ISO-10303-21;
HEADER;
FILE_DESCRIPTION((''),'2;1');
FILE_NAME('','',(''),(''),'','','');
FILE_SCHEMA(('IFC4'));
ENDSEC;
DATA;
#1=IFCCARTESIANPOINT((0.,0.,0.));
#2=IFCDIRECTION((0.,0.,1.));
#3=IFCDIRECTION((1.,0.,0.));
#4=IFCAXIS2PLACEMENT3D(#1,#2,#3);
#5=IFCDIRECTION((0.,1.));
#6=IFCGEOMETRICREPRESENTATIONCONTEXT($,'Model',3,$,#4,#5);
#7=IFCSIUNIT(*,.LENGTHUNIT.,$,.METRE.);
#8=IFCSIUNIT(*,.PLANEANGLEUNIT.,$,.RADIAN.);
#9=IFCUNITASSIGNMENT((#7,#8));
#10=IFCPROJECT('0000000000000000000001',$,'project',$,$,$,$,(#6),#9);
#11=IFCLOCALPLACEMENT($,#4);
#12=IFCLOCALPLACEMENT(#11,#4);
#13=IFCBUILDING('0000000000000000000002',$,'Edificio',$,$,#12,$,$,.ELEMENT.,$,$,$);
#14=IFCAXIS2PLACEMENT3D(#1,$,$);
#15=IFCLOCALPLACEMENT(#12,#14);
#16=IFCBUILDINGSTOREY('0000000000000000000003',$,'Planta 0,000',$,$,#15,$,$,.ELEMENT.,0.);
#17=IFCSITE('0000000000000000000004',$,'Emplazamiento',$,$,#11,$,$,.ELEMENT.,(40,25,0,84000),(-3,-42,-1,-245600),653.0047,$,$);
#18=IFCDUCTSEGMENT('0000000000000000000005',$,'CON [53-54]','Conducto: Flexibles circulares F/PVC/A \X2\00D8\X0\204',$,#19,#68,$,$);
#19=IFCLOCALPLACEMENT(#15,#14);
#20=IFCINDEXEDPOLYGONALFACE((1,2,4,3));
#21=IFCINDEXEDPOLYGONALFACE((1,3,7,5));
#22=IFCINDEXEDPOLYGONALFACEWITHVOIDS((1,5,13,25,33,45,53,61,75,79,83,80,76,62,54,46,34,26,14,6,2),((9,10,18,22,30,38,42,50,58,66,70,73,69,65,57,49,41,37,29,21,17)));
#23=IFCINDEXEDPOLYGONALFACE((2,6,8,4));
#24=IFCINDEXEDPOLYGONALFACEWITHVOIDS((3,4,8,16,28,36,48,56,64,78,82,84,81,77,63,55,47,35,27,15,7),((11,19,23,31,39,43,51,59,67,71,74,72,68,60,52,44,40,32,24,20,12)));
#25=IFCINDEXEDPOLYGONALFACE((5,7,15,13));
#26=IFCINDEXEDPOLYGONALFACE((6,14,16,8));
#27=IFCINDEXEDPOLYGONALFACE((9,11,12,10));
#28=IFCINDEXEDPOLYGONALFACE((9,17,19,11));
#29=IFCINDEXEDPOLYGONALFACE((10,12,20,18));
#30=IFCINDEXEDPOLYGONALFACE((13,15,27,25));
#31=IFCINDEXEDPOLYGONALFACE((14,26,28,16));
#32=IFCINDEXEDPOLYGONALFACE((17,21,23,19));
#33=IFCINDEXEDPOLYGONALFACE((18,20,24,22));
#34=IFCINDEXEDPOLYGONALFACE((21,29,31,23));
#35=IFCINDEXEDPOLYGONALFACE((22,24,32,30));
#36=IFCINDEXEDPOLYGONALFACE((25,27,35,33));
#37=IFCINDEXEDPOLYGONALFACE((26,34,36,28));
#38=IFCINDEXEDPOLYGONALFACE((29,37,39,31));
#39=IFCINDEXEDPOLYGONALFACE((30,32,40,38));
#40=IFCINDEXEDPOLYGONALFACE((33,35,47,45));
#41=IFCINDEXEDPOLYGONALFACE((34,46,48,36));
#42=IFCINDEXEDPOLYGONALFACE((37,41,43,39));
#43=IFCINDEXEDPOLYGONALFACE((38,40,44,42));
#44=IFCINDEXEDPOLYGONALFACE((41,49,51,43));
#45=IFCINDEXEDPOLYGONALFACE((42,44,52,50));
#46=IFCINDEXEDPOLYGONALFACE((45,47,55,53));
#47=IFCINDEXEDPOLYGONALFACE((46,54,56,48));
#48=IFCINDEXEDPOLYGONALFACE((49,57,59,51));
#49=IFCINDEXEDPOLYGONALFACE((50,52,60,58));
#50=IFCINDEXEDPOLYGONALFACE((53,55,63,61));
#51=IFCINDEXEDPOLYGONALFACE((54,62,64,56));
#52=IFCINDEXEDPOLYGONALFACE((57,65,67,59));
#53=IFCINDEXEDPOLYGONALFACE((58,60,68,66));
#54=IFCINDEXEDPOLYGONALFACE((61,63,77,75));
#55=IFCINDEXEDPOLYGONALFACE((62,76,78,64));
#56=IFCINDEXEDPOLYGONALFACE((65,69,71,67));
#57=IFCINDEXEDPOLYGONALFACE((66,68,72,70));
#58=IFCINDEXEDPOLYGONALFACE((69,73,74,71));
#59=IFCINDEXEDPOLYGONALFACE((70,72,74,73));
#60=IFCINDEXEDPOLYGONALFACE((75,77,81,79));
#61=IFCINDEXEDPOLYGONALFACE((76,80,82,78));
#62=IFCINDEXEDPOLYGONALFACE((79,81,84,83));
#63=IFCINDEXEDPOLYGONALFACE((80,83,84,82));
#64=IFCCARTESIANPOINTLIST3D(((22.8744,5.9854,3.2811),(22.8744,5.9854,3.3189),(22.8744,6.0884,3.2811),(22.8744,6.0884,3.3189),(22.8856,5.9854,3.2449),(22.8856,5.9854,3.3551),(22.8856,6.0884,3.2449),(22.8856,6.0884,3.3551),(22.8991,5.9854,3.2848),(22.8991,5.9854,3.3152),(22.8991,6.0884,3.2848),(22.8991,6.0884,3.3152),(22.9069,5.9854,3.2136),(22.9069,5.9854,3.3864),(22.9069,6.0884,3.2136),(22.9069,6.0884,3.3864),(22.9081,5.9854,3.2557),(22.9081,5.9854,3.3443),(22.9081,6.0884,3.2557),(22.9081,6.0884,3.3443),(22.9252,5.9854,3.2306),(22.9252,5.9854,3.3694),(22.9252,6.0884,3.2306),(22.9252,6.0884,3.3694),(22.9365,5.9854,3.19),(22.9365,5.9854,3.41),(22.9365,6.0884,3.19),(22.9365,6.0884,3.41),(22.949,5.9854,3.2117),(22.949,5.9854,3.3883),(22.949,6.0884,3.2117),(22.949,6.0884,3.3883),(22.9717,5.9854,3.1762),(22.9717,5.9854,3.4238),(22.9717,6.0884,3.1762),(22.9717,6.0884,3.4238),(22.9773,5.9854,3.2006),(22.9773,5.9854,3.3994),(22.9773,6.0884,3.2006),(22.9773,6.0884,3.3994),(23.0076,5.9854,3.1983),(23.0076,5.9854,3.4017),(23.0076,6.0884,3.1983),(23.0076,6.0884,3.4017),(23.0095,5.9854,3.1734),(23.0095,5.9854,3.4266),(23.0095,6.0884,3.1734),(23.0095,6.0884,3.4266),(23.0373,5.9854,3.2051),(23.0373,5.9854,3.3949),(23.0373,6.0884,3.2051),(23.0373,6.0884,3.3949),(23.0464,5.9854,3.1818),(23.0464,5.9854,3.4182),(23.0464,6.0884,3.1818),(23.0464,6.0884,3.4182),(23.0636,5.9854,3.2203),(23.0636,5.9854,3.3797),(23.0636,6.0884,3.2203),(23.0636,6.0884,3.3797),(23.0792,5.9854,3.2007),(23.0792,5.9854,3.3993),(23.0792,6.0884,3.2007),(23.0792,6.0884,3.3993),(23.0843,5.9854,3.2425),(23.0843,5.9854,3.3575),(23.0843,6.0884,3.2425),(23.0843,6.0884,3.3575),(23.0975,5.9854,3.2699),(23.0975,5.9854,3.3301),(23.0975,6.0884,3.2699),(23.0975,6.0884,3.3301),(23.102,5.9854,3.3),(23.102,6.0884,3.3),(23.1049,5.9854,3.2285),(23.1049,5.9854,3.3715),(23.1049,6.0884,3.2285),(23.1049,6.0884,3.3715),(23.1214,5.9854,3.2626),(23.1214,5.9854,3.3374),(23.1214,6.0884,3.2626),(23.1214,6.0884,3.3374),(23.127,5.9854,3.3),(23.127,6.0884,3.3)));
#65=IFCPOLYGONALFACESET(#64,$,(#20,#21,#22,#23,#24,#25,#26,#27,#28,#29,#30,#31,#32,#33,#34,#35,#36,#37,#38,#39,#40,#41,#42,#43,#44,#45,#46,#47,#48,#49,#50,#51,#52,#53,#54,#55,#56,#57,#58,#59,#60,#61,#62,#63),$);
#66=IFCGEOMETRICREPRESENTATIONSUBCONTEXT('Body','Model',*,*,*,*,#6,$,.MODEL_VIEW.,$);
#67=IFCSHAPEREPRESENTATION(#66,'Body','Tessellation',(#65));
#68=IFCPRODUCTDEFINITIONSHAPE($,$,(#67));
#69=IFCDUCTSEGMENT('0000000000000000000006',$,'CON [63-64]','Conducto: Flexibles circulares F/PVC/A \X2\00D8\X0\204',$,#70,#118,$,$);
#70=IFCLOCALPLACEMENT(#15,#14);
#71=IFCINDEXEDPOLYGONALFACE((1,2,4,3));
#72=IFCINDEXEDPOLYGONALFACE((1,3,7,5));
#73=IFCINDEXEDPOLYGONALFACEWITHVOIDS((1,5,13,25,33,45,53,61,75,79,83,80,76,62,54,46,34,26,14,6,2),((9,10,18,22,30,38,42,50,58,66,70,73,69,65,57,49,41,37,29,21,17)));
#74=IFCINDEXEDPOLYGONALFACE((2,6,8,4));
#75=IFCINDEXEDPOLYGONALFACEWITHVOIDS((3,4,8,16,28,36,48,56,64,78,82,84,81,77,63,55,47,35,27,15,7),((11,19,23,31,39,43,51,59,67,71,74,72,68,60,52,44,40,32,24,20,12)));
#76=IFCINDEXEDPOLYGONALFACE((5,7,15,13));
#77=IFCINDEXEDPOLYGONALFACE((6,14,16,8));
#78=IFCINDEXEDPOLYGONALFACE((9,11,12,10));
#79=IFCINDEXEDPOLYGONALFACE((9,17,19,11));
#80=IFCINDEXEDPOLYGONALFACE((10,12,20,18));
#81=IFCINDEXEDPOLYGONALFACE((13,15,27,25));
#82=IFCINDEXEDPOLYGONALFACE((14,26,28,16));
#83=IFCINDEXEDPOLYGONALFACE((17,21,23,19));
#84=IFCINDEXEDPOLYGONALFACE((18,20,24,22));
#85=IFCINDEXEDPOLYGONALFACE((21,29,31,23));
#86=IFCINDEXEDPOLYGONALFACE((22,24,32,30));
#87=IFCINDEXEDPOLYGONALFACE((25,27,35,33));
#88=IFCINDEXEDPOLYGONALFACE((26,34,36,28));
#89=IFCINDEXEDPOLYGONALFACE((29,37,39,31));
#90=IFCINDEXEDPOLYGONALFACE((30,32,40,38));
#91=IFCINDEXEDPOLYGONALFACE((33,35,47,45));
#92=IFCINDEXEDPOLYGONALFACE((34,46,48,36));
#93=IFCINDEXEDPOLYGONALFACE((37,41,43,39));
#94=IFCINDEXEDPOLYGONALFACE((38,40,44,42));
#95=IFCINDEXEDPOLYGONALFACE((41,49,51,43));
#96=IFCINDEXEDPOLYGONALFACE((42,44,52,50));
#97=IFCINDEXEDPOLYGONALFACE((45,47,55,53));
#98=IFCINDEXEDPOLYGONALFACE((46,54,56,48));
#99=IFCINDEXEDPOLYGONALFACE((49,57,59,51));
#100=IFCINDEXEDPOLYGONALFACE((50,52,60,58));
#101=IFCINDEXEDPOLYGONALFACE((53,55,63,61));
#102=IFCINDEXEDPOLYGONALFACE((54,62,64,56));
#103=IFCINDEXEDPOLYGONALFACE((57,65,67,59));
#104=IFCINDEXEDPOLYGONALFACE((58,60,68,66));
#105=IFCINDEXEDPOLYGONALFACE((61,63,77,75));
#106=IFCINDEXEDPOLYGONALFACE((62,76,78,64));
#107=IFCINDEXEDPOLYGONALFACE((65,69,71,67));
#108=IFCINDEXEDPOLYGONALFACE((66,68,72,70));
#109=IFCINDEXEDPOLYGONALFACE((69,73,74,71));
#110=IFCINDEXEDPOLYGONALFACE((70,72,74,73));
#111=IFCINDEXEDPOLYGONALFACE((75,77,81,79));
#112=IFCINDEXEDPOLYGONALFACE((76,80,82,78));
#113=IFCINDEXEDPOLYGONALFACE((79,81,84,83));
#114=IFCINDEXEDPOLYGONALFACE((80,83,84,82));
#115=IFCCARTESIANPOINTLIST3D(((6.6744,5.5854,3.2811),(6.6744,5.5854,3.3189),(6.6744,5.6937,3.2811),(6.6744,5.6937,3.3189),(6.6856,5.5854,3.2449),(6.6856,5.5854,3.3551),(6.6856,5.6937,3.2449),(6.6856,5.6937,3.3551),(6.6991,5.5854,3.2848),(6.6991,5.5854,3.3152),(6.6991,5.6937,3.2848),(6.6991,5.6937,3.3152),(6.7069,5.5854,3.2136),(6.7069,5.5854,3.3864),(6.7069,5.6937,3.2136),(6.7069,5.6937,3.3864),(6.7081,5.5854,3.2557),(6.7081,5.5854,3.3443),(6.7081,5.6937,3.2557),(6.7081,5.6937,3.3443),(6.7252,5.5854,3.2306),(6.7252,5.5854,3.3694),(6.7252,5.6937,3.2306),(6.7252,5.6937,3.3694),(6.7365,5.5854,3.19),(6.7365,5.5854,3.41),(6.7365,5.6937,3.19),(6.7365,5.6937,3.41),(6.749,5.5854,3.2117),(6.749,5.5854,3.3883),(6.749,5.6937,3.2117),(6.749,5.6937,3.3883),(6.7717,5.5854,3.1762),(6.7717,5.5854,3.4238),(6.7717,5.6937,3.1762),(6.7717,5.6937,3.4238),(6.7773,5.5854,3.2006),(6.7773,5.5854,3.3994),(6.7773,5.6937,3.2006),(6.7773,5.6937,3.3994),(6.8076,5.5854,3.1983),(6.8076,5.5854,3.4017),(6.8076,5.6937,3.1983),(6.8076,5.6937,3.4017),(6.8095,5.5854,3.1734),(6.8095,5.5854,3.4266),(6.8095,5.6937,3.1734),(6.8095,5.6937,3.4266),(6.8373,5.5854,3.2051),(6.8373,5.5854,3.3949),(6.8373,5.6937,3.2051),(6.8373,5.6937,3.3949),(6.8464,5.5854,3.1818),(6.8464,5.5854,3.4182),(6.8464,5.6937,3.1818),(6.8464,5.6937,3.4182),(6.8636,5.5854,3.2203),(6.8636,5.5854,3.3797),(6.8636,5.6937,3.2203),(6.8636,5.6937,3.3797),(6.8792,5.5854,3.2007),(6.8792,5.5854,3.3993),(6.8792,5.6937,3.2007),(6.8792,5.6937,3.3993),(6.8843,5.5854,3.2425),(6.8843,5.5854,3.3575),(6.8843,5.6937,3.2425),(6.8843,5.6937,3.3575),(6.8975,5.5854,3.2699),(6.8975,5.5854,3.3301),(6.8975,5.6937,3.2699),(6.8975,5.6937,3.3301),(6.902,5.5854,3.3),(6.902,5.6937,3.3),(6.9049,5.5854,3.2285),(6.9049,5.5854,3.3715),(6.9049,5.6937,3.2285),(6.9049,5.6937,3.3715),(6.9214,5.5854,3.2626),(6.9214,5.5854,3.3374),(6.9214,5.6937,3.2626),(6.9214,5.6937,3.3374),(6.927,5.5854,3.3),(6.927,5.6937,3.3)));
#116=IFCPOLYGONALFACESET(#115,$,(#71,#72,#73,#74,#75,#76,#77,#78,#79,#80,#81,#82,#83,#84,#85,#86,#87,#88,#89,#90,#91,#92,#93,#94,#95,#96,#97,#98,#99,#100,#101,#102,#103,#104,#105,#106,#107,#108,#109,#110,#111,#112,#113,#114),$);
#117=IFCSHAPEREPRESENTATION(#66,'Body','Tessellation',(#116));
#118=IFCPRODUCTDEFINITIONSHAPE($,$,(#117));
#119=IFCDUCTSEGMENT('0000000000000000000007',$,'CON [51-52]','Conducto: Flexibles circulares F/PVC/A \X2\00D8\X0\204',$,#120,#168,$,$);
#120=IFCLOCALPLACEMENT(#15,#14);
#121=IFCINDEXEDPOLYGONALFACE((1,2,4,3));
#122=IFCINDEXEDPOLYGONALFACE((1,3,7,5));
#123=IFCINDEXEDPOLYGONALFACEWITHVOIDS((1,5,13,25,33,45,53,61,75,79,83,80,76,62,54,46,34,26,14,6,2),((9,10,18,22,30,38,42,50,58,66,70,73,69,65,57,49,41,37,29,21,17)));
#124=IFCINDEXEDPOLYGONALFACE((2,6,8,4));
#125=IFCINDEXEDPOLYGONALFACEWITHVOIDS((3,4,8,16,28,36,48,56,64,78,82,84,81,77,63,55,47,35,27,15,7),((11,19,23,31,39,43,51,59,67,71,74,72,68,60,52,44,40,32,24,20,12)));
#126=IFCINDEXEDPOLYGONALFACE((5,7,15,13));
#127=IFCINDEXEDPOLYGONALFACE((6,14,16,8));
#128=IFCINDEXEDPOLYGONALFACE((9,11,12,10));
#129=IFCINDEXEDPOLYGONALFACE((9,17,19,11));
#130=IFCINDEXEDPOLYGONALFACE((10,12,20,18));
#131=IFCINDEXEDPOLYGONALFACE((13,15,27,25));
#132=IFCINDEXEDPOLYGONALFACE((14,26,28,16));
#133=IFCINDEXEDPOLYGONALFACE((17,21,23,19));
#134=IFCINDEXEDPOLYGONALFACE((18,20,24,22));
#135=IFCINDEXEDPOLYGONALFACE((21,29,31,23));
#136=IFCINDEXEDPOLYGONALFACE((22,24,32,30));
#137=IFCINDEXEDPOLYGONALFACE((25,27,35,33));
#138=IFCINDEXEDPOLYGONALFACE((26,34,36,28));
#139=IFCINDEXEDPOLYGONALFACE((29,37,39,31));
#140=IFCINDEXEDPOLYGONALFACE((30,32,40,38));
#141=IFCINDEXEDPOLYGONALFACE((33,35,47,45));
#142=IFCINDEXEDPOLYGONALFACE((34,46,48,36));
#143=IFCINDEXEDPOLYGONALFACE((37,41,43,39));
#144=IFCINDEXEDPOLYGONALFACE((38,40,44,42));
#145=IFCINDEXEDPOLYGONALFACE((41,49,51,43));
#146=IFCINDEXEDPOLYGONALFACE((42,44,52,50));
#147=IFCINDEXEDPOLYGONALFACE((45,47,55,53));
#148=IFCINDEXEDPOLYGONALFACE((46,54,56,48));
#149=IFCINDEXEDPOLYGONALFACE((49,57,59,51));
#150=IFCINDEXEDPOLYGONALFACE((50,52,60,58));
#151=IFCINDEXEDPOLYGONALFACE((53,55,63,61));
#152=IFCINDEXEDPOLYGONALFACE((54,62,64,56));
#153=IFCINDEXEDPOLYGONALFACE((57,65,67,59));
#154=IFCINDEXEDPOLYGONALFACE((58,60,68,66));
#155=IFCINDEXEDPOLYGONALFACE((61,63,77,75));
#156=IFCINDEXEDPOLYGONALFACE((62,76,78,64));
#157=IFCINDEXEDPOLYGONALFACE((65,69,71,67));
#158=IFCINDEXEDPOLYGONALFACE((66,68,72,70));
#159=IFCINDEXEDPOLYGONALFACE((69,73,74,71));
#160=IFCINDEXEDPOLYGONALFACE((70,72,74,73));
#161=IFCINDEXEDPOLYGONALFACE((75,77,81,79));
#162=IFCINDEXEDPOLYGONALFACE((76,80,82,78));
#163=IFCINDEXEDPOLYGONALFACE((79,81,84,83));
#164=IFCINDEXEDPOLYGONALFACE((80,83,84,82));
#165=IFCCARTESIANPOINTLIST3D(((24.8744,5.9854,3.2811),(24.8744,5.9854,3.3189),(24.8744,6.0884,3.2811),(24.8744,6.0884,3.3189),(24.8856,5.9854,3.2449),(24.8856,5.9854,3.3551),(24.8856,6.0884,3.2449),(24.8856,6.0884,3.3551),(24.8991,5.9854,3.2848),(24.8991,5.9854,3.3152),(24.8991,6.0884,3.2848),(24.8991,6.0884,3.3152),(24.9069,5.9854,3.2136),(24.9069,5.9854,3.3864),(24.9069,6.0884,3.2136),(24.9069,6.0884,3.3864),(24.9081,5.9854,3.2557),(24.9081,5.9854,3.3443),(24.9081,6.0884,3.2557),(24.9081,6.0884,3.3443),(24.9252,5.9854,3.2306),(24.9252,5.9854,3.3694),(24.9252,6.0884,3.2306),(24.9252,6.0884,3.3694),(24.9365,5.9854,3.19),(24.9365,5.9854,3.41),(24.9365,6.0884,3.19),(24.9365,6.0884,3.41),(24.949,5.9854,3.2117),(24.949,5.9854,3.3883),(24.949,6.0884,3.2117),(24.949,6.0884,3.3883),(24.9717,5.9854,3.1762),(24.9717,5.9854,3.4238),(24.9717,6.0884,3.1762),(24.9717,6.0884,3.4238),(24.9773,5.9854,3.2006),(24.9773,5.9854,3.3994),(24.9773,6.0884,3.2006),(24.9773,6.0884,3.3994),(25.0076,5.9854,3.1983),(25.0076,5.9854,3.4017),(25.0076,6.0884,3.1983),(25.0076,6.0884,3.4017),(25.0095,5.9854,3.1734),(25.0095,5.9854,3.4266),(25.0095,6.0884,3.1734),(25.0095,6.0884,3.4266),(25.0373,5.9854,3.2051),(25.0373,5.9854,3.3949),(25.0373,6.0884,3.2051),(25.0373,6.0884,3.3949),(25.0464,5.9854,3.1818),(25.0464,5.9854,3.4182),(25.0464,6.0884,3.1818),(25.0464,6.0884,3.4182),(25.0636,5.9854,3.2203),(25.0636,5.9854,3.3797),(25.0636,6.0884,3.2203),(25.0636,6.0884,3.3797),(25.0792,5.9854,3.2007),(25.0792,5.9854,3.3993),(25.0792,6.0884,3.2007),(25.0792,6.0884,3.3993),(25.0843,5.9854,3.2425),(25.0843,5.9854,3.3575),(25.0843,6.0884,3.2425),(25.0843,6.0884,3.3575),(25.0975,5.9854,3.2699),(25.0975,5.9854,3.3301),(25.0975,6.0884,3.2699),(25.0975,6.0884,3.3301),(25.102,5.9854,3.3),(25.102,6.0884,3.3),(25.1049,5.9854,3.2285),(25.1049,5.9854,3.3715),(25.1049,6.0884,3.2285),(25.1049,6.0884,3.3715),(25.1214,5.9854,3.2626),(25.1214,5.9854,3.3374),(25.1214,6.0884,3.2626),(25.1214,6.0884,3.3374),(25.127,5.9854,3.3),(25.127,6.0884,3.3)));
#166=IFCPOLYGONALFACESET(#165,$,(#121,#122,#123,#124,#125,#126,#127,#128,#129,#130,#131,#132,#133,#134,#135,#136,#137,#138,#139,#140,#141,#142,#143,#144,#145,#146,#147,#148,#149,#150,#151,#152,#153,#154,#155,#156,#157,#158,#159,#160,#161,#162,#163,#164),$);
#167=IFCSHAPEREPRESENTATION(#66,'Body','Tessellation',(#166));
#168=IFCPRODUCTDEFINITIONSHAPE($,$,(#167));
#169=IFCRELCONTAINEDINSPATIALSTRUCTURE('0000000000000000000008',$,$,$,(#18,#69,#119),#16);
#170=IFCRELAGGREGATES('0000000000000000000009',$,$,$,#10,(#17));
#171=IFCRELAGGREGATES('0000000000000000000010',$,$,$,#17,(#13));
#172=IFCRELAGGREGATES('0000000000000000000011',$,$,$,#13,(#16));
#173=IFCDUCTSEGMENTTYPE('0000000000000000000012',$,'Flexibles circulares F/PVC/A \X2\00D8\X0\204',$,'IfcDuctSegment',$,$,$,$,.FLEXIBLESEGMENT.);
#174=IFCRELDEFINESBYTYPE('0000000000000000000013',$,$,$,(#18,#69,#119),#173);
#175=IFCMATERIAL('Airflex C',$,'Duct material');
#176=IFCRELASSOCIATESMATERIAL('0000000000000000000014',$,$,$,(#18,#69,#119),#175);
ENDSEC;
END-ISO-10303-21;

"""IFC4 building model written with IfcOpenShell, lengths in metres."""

from ifc_helpers import new_model, si_unit, direction, frame, origin, origin_with_axes, origin_2d_with_axis, place, context, subcontext, project, spatial, hollow_circle, extrude, material, type_object, element, save


model = new_model("IFC4")

# Units and contexts
model_context = context("Model", 3, world=origin_with_axes(), true_north=direction((0.0, 1.0)))
body_context = subcontext(model_context, "Body", "Model", "MODEL_VIEW")
ifc_project = project(units=[si_unit("LENGTHUNIT", "METRE"), si_unit("PLANEANGLEUNIT", "RADIAN")], contexts=[model_context])

# Site, building, storey
site_placement = place(None, origin_with_axes())
site = spatial("IfcSite", under=ifc_project, at=site_placement, Name="Emplazamiento", CompositionType="ELEMENT", RefLatitude=(40, 25, 0, 84000), RefLongitude=(-3, -42, -1, -245600), RefElevation=653.0047)
building_placement = place(site_placement, origin_with_axes())
building = spatial("IfcBuilding", under=site, at=building_placement, Name="Edificio", CompositionType="ELEMENT")
storey_placement = place(building_placement, origin())
storey = spatial("IfcBuildingStorey", under=building, at=storey_placement, Name="Planta 0,000", CompositionType="ELEMENT", Elevation=0.0)

# Shared definitions
ifc_material_1 = material(Name="Airflex C", Category="Duct material")

# Duct segments
duct_segment_type_1 = type_object("IfcDuctSegmentType", Name="Flexibles circulares F/PVC/A Ø204", ApplicableOccurrence="IfcDuctSegment", PredefinedType="FLEXIBLESEGMENT")
duct_segment_1_placement = place(storey_placement, origin_with_axes())
element("IfcDuctSegment", 1, at=duct_segment_1_placement, inside=storey, type_object=duct_segment_type_1, material=ifc_material_1, Name="CON [53-54]", Description="Conducto: Flexibles circulares F/PVC/A Ø204", context=body_context, shape_type="SweptSolid", body=[
    extrude(hollow_circle(Radius=0.127, WallThickness=0.025, at=origin_2d_with_axis()), frame((23.0, 6.0884, 3.3), z_axis=(0.0, -1.0, 0.0), x_axis=(1.0, 0.0, 0.0)), (0.0, 0.0, 1.0), 0.103),
])
duct_segment_2_placement = place(storey_placement, origin_with_axes())
element("IfcDuctSegment", 2, at=duct_segment_2_placement, inside=storey, type_object=duct_segment_type_1, material=ifc_material_1, Name="CON [63-64]", Description="Conducto: Flexibles circulares F/PVC/A Ø204", context=body_context, shape_type="SweptSolid", body=[
    extrude(hollow_circle(Radius=0.127, WallThickness=0.025, at=origin_2d_with_axis()), frame((6.8, 5.6937, 3.3), z_axis=(0.0, -1.0, 0.0), x_axis=(1.0, 0.0, 0.0)), (0.0, 0.0, 1.0), 0.1082),
])
duct_segment_3_placement = place(storey_placement, origin_with_axes())
element("IfcDuctSegment", 3, at=duct_segment_3_placement, inside=storey, type_object=duct_segment_type_1, material=ifc_material_1, Name="CON [51-52]", Description="Conducto: Flexibles circulares F/PVC/A Ø204", context=body_context, shape_type="SweptSolid", body=[
    extrude(hollow_circle(Radius=0.127, WallThickness=0.025, at=origin_2d_with_axis()), frame((25.0, 6.0884, 3.3), z_axis=(0.0, -1.0, 0.0), x_axis=(1.0, 0.0, 0.0)), (0.0, 0.0, 1.0), 0.103),
])

save(model, "model.ifc")
